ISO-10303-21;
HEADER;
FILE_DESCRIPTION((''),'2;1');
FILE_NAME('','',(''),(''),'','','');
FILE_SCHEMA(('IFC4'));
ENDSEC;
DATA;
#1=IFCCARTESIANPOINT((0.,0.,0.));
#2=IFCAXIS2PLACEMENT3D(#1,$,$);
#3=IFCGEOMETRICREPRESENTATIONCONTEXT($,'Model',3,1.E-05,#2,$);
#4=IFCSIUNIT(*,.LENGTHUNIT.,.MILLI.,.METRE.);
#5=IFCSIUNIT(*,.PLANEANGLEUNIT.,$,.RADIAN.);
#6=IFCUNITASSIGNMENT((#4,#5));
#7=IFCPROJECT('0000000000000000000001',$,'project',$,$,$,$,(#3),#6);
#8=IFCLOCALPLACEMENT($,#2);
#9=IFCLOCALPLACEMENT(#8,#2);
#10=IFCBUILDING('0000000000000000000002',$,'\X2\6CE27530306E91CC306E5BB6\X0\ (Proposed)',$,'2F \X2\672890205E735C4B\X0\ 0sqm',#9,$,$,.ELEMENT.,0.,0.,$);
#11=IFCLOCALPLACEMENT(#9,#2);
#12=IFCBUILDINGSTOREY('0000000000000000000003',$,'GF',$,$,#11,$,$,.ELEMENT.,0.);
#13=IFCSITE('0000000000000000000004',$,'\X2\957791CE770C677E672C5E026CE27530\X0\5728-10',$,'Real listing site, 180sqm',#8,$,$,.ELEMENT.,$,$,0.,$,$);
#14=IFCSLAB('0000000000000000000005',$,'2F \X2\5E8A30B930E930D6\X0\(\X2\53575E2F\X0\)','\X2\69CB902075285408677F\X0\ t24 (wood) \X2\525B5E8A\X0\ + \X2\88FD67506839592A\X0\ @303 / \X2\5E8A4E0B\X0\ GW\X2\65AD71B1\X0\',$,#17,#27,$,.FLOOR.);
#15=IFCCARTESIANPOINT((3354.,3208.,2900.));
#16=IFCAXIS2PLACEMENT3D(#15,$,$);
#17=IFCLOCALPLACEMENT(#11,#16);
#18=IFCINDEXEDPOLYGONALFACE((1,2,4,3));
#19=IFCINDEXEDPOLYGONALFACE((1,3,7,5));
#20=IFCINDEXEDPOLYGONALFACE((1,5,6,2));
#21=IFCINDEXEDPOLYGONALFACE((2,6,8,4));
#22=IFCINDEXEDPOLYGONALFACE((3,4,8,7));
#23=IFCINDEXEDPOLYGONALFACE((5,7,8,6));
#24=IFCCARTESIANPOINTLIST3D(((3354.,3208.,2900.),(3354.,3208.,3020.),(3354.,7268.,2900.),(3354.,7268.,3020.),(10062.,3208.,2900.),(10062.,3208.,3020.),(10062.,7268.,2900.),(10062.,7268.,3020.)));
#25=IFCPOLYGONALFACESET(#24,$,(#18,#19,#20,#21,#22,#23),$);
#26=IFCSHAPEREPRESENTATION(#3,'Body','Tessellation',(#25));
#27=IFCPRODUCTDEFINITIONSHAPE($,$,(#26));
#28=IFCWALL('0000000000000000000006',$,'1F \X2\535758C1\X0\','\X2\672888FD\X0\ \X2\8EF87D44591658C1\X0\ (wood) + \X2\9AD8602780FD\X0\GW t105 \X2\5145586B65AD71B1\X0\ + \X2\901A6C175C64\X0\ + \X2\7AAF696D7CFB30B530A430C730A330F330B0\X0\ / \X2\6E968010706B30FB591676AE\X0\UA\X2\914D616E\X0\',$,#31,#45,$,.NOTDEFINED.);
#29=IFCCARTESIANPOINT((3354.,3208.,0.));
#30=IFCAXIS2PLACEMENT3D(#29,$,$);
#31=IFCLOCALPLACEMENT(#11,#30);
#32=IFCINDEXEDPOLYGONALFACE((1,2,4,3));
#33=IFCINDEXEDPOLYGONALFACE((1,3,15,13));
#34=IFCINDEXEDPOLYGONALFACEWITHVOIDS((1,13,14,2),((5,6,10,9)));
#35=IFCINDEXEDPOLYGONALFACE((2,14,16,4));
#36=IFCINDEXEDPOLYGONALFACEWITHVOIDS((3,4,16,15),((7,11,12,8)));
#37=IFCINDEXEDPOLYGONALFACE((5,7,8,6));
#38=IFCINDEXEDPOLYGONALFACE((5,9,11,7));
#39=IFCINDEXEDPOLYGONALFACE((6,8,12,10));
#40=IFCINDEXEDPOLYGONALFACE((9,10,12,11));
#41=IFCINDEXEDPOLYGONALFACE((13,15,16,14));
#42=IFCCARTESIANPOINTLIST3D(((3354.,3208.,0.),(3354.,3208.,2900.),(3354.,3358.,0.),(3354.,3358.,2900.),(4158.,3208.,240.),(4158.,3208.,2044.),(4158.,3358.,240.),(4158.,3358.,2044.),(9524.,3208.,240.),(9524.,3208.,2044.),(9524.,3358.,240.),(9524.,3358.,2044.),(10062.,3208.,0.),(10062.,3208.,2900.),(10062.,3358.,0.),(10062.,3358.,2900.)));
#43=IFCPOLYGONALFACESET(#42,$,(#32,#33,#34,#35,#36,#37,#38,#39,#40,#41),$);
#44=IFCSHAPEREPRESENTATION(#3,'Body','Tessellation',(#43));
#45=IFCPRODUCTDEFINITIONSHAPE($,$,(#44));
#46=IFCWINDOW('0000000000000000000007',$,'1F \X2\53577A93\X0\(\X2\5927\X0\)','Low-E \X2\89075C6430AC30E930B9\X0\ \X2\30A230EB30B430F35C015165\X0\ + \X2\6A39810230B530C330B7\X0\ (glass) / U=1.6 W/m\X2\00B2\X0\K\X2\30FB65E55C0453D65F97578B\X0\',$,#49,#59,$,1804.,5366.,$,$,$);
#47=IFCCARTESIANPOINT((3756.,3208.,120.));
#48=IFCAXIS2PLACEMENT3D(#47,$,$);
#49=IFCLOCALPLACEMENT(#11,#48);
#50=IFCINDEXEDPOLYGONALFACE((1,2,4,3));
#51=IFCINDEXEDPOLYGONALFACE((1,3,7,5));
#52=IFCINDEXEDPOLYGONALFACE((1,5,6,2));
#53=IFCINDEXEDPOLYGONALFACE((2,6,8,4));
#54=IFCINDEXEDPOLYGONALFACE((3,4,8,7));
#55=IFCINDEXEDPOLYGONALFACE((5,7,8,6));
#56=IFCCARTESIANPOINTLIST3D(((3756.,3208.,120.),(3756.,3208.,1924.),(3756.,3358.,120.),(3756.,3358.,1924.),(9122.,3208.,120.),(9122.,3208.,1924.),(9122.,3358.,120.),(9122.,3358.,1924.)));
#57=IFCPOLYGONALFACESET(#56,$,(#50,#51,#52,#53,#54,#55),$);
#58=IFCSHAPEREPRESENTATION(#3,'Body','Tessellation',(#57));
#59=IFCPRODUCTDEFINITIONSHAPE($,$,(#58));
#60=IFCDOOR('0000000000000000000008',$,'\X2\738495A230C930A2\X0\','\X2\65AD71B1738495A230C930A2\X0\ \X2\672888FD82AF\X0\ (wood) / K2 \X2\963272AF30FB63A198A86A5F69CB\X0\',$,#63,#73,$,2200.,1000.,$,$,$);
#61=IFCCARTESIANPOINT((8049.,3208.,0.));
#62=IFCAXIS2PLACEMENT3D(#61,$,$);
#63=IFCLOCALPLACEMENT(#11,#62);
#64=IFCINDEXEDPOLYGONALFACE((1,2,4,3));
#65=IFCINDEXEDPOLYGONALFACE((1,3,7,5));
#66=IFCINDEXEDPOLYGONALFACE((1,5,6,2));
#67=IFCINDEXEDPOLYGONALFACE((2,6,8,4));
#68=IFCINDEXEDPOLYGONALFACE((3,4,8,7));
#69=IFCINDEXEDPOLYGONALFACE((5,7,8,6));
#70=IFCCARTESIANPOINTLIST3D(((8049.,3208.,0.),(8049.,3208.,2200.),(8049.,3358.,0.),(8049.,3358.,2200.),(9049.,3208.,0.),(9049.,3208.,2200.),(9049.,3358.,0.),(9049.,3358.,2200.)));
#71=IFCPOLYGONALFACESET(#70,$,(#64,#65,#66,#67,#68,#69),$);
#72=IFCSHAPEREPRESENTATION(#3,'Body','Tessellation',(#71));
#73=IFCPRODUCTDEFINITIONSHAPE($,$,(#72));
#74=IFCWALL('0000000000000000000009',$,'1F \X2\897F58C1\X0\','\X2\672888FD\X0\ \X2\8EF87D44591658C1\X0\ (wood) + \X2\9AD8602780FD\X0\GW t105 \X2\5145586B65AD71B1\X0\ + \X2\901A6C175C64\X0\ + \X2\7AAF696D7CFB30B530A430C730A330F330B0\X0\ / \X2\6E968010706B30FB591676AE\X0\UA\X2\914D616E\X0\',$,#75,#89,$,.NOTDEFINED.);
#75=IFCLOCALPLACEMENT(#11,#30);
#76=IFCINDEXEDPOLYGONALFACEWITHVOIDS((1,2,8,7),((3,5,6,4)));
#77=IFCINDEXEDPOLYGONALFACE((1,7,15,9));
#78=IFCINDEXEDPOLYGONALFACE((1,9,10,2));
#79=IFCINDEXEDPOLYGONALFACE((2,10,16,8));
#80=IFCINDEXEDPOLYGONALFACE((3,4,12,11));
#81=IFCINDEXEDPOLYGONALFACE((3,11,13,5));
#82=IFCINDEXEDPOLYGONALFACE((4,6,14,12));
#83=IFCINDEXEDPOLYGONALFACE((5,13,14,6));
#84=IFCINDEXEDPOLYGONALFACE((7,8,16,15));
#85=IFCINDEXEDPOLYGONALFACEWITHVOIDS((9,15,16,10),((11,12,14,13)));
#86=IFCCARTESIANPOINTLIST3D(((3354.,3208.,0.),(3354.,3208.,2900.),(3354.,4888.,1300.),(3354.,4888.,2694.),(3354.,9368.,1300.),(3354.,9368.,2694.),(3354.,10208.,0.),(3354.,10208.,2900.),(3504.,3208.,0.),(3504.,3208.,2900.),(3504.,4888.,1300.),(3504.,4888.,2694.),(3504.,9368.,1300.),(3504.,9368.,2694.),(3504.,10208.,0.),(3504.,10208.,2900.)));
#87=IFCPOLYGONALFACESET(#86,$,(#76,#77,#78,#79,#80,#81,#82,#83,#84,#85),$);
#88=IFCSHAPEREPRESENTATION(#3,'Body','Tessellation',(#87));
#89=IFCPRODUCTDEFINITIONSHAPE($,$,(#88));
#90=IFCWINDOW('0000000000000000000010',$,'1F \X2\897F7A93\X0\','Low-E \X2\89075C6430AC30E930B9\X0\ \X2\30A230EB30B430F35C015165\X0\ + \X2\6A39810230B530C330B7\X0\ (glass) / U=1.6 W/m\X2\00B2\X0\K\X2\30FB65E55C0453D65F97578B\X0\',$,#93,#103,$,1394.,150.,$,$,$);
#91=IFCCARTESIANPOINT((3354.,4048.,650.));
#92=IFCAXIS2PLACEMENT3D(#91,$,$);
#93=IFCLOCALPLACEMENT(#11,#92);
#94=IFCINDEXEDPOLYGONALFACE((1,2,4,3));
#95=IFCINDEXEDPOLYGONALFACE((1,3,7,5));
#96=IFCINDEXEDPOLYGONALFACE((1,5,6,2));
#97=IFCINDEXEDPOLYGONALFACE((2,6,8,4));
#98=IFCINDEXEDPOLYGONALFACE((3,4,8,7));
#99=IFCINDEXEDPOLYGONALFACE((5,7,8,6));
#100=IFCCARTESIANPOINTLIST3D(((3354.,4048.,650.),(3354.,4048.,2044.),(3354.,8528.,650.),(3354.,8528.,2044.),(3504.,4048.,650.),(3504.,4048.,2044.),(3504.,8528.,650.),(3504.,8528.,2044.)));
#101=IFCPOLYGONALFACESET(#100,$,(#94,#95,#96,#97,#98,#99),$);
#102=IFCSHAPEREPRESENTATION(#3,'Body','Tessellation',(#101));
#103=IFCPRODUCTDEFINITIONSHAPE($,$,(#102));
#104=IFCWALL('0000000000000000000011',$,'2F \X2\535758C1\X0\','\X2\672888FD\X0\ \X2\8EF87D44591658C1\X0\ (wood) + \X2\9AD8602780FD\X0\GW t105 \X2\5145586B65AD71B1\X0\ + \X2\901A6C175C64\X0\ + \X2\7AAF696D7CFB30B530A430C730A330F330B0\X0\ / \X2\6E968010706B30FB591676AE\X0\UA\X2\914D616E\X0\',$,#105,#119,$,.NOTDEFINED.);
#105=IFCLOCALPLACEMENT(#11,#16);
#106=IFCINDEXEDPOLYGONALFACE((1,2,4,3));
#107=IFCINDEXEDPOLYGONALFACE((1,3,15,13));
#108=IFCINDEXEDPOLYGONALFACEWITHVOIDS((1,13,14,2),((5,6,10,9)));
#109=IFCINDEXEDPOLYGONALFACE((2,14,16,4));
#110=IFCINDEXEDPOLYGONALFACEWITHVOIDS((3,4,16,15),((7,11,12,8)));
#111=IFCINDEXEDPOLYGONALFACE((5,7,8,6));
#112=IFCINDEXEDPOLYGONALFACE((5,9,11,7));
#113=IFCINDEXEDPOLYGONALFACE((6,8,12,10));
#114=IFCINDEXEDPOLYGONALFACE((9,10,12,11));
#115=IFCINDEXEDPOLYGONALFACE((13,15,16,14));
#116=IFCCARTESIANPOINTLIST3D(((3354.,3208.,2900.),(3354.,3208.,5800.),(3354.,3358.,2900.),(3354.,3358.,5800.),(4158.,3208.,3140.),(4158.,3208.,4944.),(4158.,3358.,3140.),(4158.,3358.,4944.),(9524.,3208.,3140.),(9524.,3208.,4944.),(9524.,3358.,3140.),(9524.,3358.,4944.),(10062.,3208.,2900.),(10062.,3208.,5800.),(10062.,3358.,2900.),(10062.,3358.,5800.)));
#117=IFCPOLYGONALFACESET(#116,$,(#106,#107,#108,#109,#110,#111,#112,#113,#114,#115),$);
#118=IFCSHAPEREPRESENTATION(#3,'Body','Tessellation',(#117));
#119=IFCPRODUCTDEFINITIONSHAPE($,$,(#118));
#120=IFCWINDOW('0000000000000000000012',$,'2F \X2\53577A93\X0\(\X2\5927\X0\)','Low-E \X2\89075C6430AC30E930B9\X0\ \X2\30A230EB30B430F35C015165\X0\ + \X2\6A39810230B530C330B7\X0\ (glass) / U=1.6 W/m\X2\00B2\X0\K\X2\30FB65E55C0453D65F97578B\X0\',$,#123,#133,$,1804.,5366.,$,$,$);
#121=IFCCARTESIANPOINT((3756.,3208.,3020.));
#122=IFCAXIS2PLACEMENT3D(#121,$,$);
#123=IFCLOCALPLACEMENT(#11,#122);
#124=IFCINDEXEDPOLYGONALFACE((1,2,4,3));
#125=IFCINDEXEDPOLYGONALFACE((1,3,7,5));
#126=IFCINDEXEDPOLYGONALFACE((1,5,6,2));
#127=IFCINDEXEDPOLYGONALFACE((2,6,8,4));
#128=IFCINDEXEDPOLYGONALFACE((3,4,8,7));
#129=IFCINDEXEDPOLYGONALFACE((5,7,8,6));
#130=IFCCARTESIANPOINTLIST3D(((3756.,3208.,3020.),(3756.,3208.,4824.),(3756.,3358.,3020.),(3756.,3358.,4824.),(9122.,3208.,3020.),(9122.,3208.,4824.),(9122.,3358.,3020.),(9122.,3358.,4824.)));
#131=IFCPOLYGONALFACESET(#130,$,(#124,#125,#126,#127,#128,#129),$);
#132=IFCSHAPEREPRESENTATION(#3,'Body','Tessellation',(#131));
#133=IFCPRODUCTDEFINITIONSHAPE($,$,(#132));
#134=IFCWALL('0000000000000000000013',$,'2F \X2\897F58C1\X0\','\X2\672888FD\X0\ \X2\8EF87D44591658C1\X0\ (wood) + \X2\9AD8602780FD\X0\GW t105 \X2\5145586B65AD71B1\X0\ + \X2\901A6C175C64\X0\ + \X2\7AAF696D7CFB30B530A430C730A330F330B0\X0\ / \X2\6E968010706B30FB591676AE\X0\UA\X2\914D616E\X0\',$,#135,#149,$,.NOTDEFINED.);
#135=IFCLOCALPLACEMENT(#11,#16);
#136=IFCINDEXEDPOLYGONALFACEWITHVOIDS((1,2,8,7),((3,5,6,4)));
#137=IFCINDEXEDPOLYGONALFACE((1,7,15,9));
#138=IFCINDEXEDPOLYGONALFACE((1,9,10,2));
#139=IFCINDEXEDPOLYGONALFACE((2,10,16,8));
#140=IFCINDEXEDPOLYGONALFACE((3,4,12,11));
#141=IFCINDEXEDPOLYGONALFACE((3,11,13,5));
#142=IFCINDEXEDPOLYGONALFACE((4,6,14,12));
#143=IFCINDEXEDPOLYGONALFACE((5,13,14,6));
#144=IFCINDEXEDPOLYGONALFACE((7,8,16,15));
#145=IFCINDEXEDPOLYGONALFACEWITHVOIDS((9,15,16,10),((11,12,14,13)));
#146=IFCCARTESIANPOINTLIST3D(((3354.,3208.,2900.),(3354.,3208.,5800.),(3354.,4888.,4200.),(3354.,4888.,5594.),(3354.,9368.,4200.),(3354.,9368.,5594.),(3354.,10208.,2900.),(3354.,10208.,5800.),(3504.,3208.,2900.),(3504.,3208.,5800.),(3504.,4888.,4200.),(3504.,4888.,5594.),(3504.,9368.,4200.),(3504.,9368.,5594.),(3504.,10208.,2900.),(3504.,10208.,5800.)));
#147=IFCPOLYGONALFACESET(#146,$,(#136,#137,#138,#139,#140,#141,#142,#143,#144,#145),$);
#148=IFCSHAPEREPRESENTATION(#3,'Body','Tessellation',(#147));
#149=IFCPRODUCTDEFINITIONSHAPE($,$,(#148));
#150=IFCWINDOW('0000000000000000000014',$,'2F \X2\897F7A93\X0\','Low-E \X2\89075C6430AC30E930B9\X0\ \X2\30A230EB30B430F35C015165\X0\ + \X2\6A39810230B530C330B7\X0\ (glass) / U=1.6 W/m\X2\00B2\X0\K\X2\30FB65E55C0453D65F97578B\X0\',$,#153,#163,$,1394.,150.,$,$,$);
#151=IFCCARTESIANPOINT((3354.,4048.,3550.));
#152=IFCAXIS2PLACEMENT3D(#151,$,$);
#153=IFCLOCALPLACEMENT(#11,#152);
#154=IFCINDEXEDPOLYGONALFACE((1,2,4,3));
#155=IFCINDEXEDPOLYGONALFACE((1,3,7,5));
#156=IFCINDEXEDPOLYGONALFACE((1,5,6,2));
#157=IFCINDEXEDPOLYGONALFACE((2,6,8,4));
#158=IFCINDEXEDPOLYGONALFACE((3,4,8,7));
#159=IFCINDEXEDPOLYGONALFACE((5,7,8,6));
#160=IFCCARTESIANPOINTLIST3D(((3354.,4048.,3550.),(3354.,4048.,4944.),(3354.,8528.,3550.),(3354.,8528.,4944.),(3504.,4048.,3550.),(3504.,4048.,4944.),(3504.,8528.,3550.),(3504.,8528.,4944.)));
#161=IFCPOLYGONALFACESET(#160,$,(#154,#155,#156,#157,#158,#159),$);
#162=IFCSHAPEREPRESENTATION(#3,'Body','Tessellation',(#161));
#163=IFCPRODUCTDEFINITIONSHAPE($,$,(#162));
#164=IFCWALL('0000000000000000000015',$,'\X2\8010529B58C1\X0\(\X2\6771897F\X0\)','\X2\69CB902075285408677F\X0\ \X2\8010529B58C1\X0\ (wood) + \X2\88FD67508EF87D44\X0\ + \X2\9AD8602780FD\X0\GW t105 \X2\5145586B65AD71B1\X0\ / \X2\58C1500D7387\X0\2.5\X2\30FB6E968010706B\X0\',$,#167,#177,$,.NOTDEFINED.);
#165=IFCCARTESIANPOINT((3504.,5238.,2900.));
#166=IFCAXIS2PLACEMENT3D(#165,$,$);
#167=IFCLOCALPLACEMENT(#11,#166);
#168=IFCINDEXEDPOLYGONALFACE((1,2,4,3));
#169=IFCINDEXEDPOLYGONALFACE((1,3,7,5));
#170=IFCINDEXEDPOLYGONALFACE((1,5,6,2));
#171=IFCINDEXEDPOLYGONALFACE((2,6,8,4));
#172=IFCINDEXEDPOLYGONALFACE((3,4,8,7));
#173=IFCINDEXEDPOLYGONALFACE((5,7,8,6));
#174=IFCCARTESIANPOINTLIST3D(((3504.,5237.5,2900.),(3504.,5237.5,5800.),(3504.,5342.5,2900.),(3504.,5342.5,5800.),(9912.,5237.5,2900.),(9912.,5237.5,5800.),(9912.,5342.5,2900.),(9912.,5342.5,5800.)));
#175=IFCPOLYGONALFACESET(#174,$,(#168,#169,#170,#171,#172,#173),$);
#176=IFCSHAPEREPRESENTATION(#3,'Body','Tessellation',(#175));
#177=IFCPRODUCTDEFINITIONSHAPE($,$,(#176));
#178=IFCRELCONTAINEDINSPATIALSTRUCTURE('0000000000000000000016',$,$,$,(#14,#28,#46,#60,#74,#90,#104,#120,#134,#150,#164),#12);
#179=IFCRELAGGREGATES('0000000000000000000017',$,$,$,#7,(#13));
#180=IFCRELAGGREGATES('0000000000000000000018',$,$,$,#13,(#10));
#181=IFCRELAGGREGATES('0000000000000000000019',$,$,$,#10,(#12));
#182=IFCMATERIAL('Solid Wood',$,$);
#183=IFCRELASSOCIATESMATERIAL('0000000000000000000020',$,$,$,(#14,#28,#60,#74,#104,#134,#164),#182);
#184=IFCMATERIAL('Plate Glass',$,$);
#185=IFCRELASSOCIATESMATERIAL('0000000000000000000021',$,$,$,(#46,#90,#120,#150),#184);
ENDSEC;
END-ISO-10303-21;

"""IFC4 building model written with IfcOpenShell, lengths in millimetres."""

from ifc_helpers import new_model, si_unit, frame, frame_2d, origin, place, context, project, spatial, rectangle, extrude, material, element, fill, save


model = new_model("IFC4")

# Units and contexts
model_context = context("Model", 3, precision=1e-05, world=origin())
ifc_project = project(units=[si_unit("LENGTHUNIT", "METRE", prefix="MILLI"), si_unit("PLANEANGLEUNIT", "RADIAN")], contexts=[model_context])

# Site, building, storey
site_placement = place(None, origin())
site = spatial("IfcSite", under=ifc_project, at=site_placement, Name="長野県松本市波田5728-10", ObjectType="Real listing site, 180sqm", CompositionType="ELEMENT", RefElevation=0.0)
building_placement = place(site_placement, origin())
building = spatial("IfcBuilding", under=site, at=building_placement, Name="波田の里の家 (Proposed)", ObjectType="2F 木造平屋 0sqm", CompositionType="ELEMENT", ElevationOfRefHeight=0.0, ElevationOfTerrain=0.0)
storey_placement = place(building_placement, origin())
storey = spatial("IfcBuildingStorey", under=building, at=storey_placement, Name="GF", CompositionType="ELEMENT", Elevation=0.0)

# Slab
ifc_material_1 = material(Name="Solid Wood")
slab_1_placement = place(storey_placement, frame((3354.0, 3208.0, 2900.0)))
element("IfcSlab", 1, at=slab_1_placement, inside=storey, material=ifc_material_1, Name="2F 床スラブ(南帯)", Description="構造用合板 t24 (wood) 剛床 + 製材根太 @303 / 床下 GW断熱", PredefinedType="FLOOR", context=model_context, shape_type="SweptSolid", body=[
    extrude(rectangle(XDim=6708.0, YDim=4060.0, at=frame_2d((3354.0, 2030.0))), frame((3354.0, 3208.0, 2900.0)), (0.0, 0.0, 1.0), 120.0),
])

# Wall, openings, window, door
wall_1_placement = place(storey_placement, frame((3354.0, 3208.0, 0.0)))
wall_1 = element("IfcWall", 2, at=wall_1_placement, inside=storey, material=ifc_material_1, Name="1F 南壁", Description="木製 軸組外壁 (wood) + 高性能GW t105 充填断熱 + 通気層 + 窯業系サイディング / 準耐火・外皮UA配慮", PredefinedType="NOTDEFINED", context=model_context, shape_type="SweptSolid", body=[
    extrude(rectangle(XDim=6708.0, YDim=150.0, at=frame_2d((3354.0, 75.0))), frame((3354.0, 3208.0, 0.0)), (0.0, 0.0, 1.0), 2900.0),
])
opening_1_placement = place(storey_placement, frame((3756.0, 3208.0, 120.0)))
opening_1 = element("IfcOpeningElement", 3, at=opening_1_placement, cuts=wall_1, PredefinedType="NOTDEFINED", context=model_context, shape_type="SweptSolid", body=[
    extrude(rectangle(XDim=5366.0, YDim=150.0, at=frame_2d((2683.0, 75.0))), frame((3756.0, 3208.0, 120.0)), (0.0, 0.0, 1.0), 1804.0),
])
opening_2_placement = place(storey_placement, frame((8049.0, 3208.0, 0.0)))
opening_2 = element("IfcOpeningElement", 4, at=opening_2_placement, cuts=wall_1, PredefinedType="NOTDEFINED", context=model_context, shape_type="SweptSolid", body=[
    extrude(rectangle(XDim=1000.0, YDim=150.0, at=frame_2d((500.0, 75.0))), frame((8049.0, 3208.0, 0.0)), (0.0, 0.0, 1.0), 2200.0),
])
ifc_material_2 = material(Name="Plate Glass")
window_1_placement = place(storey_placement, frame((3756.0, 3208.0, 120.0)))
window_1 = element("IfcWindow", 5, at=window_1_placement, inside=storey, material=ifc_material_2, Name="1F 南窓(大)", Description="Low-E 複層ガラス アルゴン封入 + 樹脂サッシ (glass) / U=1.6 W/m²K・日射取得型", OverallHeight=1804.0, OverallWidth=5366.0, context=model_context, shape_type="SweptSolid", body=[
    extrude(rectangle(XDim=5366.0, YDim=150.0, at=frame_2d((2683.0, 75.0))), frame((3756.0, 3208.0, 120.0)), (0.0, 0.0, 1.0), 1804.0),
])
fill(opening_1, window_1)
door_placement = place(storey_placement, frame((8049.0, 3208.0, 0.0)))
door = element("IfcDoor", 6, at=door_placement, inside=storey, material=ifc_material_1, Name="玄関ドア", Description="断熱玄関ドア 木製芯 (wood) / K2 防犯・採風機構", OverallHeight=2200.0, OverallWidth=1000.0, context=model_context, shape_type="SweptSolid", body=[
    extrude(rectangle(XDim=1000.0, YDim=150.0, at=frame_2d((500.0, 75.0))), frame((8049.0, 3208.0, 0.0)), (0.0, 0.0, 1.0), 2200.0),
])
fill(opening_2, door)

# Wall, opening, window
wall_2_placement = place(storey_placement, frame((3354.0, 3208.0, 0.0)))
wall_2 = element("IfcWall", 7, at=wall_2_placement, inside=storey, material=ifc_material_1, Name="1F 西壁", Description="木製 軸組外壁 (wood) + 高性能GW t105 充填断熱 + 通気層 + 窯業系サイディング / 準耐火・外皮UA配慮", PredefinedType="NOTDEFINED", context=model_context, shape_type="SweptSolid", body=[
    extrude(rectangle(XDim=150.0, YDim=7000.0, at=frame_2d((75.0, 3500.0))), frame((3354.0, 3208.0, 0.0)), (0.0, 0.0, 1.0), 2900.0),
])
opening_3_placement = place(storey_placement, frame((3354.0, 4048.0, 650.0)))
opening_3 = element("IfcOpeningElement", 8, at=opening_3_placement, cuts=wall_2, PredefinedType="NOTDEFINED", context=model_context, shape_type="SweptSolid", body=[
    extrude(rectangle(XDim=150.0, YDim=4480.0, at=frame_2d((75.0, 2240.0))), frame((3354.0, 4048.0, 650.0)), (0.0, 0.0, 1.0), 1394.0),
])
window_2_placement = place(storey_placement, frame((3354.0, 4048.0, 650.0)))
window_2 = element("IfcWindow", 9, at=window_2_placement, inside=storey, material=ifc_material_2, Name="1F 西窓", Description="Low-E 複層ガラス アルゴン封入 + 樹脂サッシ (glass) / U=1.6 W/m²K・日射取得型", OverallHeight=1394.0, OverallWidth=150.0, context=model_context, shape_type="SweptSolid", body=[
    extrude(rectangle(XDim=150.0, YDim=4480.0, at=frame_2d((75.0, 2240.0))), frame((3354.0, 4048.0, 650.0)), (0.0, 0.0, 1.0), 1394.0),
])
fill(opening_3, window_2)

# Walls, openings, windows
wall_3_placement = place(storey_placement, frame((3354.0, 3208.0, 2900.0)))
wall_3 = element("IfcWall", 10, at=wall_3_placement, inside=storey, material=ifc_material_1, Name="2F 南壁", Description="木製 軸組外壁 (wood) + 高性能GW t105 充填断熱 + 通気層 + 窯業系サイディング / 準耐火・外皮UA配慮", PredefinedType="NOTDEFINED", context=model_context, shape_type="SweptSolid", body=[
    extrude(rectangle(XDim=6708.0, YDim=150.0, at=frame_2d((3354.0, 75.0))), frame((3354.0, 3208.0, 2900.0)), (0.0, 0.0, 1.0), 2900.0),
])
opening_4_placement = place(storey_placement, frame((3756.0, 3208.0, 3020.0)))
opening_4 = element("IfcOpeningElement", 11, at=opening_4_placement, cuts=wall_3, PredefinedType="NOTDEFINED", context=model_context, shape_type="SweptSolid", body=[
    extrude(rectangle(XDim=5366.0, YDim=150.0, at=frame_2d((2683.0, 75.0))), frame((3756.0, 3208.0, 3020.0)), (0.0, 0.0, 1.0), 1804.0),
])
window_3_placement = place(storey_placement, frame((3756.0, 3208.0, 3020.0)))
window_3 = element("IfcWindow", 12, at=window_3_placement, inside=storey, material=ifc_material_2, Name="2F 南窓(大)", Description="Low-E 複層ガラス アルゴン封入 + 樹脂サッシ (glass) / U=1.6 W/m²K・日射取得型", OverallHeight=1804.0, OverallWidth=5366.0, context=model_context, shape_type="SweptSolid", body=[
    extrude(rectangle(XDim=5366.0, YDim=150.0, at=frame_2d((2683.0, 75.0))), frame((3756.0, 3208.0, 3020.0)), (0.0, 0.0, 1.0), 1804.0),
])
fill(opening_4, window_3)
wall_4_placement = place(storey_placement, frame((3354.0, 3208.0, 2900.0)))
wall_4 = element("IfcWall", 13, at=wall_4_placement, inside=storey, material=ifc_material_1, Name="2F 西壁", Description="木製 軸組外壁 (wood) + 高性能GW t105 充填断熱 + 通気層 + 窯業系サイディング / 準耐火・外皮UA配慮", PredefinedType="NOTDEFINED", context=model_context, shape_type="SweptSolid", body=[
    extrude(rectangle(XDim=150.0, YDim=7000.0, at=frame_2d((75.0, 3500.0))), frame((3354.0, 3208.0, 2900.0)), (0.0, 0.0, 1.0), 2900.0),
])
opening_5_placement = place(storey_placement, frame((3354.0, 4048.0, 3550.0)))
opening_5 = element("IfcOpeningElement", 14, at=opening_5_placement, cuts=wall_4, PredefinedType="NOTDEFINED", context=model_context, shape_type="SweptSolid", body=[
    extrude(rectangle(XDim=150.0, YDim=4480.0, at=frame_2d((75.0, 2240.0))), frame((3354.0, 4048.0, 3550.0)), (0.0, 0.0, 1.0), 1394.0),
])
window_4_placement = place(storey_placement, frame((3354.0, 4048.0, 3550.0)))
window_4 = element("IfcWindow", 15, at=window_4_placement, inside=storey, material=ifc_material_2, Name="2F 西窓", Description="Low-E 複層ガラス アルゴン封入 + 樹脂サッシ (glass) / U=1.6 W/m²K・日射取得型", OverallHeight=1394.0, OverallWidth=150.0, context=model_context, shape_type="SweptSolid", body=[
    extrude(rectangle(XDim=150.0, YDim=4480.0, at=frame_2d((75.0, 2240.0))), frame((3354.0, 4048.0, 3550.0)), (0.0, 0.0, 1.0), 1394.0),
])
fill(opening_5, window_4)

# Wall
wall_5_placement = place(storey_placement, frame((3504.0, 5238.0, 2900.0)))
element("IfcWall", 16, at=wall_5_placement, inside=storey, material=ifc_material_1, Name="耐力壁(東西)", Description="構造用合板 耐力壁 (wood) + 製材軸組 + 高性能GW t105 充填断熱 / 壁倍率2.5・準耐火", PredefinedType="NOTDEFINED", context=model_context, shape_type="SweptSolid", body=[
    extrude(rectangle(XDim=6408.0, YDim=105.0, at=frame_2d((3204.0, 52.0))), frame((3504.0, 5238.0, 2900.0)), (0.0, 0.0, 1.0), 2900.0),
])

save(model, "model.ifc")
